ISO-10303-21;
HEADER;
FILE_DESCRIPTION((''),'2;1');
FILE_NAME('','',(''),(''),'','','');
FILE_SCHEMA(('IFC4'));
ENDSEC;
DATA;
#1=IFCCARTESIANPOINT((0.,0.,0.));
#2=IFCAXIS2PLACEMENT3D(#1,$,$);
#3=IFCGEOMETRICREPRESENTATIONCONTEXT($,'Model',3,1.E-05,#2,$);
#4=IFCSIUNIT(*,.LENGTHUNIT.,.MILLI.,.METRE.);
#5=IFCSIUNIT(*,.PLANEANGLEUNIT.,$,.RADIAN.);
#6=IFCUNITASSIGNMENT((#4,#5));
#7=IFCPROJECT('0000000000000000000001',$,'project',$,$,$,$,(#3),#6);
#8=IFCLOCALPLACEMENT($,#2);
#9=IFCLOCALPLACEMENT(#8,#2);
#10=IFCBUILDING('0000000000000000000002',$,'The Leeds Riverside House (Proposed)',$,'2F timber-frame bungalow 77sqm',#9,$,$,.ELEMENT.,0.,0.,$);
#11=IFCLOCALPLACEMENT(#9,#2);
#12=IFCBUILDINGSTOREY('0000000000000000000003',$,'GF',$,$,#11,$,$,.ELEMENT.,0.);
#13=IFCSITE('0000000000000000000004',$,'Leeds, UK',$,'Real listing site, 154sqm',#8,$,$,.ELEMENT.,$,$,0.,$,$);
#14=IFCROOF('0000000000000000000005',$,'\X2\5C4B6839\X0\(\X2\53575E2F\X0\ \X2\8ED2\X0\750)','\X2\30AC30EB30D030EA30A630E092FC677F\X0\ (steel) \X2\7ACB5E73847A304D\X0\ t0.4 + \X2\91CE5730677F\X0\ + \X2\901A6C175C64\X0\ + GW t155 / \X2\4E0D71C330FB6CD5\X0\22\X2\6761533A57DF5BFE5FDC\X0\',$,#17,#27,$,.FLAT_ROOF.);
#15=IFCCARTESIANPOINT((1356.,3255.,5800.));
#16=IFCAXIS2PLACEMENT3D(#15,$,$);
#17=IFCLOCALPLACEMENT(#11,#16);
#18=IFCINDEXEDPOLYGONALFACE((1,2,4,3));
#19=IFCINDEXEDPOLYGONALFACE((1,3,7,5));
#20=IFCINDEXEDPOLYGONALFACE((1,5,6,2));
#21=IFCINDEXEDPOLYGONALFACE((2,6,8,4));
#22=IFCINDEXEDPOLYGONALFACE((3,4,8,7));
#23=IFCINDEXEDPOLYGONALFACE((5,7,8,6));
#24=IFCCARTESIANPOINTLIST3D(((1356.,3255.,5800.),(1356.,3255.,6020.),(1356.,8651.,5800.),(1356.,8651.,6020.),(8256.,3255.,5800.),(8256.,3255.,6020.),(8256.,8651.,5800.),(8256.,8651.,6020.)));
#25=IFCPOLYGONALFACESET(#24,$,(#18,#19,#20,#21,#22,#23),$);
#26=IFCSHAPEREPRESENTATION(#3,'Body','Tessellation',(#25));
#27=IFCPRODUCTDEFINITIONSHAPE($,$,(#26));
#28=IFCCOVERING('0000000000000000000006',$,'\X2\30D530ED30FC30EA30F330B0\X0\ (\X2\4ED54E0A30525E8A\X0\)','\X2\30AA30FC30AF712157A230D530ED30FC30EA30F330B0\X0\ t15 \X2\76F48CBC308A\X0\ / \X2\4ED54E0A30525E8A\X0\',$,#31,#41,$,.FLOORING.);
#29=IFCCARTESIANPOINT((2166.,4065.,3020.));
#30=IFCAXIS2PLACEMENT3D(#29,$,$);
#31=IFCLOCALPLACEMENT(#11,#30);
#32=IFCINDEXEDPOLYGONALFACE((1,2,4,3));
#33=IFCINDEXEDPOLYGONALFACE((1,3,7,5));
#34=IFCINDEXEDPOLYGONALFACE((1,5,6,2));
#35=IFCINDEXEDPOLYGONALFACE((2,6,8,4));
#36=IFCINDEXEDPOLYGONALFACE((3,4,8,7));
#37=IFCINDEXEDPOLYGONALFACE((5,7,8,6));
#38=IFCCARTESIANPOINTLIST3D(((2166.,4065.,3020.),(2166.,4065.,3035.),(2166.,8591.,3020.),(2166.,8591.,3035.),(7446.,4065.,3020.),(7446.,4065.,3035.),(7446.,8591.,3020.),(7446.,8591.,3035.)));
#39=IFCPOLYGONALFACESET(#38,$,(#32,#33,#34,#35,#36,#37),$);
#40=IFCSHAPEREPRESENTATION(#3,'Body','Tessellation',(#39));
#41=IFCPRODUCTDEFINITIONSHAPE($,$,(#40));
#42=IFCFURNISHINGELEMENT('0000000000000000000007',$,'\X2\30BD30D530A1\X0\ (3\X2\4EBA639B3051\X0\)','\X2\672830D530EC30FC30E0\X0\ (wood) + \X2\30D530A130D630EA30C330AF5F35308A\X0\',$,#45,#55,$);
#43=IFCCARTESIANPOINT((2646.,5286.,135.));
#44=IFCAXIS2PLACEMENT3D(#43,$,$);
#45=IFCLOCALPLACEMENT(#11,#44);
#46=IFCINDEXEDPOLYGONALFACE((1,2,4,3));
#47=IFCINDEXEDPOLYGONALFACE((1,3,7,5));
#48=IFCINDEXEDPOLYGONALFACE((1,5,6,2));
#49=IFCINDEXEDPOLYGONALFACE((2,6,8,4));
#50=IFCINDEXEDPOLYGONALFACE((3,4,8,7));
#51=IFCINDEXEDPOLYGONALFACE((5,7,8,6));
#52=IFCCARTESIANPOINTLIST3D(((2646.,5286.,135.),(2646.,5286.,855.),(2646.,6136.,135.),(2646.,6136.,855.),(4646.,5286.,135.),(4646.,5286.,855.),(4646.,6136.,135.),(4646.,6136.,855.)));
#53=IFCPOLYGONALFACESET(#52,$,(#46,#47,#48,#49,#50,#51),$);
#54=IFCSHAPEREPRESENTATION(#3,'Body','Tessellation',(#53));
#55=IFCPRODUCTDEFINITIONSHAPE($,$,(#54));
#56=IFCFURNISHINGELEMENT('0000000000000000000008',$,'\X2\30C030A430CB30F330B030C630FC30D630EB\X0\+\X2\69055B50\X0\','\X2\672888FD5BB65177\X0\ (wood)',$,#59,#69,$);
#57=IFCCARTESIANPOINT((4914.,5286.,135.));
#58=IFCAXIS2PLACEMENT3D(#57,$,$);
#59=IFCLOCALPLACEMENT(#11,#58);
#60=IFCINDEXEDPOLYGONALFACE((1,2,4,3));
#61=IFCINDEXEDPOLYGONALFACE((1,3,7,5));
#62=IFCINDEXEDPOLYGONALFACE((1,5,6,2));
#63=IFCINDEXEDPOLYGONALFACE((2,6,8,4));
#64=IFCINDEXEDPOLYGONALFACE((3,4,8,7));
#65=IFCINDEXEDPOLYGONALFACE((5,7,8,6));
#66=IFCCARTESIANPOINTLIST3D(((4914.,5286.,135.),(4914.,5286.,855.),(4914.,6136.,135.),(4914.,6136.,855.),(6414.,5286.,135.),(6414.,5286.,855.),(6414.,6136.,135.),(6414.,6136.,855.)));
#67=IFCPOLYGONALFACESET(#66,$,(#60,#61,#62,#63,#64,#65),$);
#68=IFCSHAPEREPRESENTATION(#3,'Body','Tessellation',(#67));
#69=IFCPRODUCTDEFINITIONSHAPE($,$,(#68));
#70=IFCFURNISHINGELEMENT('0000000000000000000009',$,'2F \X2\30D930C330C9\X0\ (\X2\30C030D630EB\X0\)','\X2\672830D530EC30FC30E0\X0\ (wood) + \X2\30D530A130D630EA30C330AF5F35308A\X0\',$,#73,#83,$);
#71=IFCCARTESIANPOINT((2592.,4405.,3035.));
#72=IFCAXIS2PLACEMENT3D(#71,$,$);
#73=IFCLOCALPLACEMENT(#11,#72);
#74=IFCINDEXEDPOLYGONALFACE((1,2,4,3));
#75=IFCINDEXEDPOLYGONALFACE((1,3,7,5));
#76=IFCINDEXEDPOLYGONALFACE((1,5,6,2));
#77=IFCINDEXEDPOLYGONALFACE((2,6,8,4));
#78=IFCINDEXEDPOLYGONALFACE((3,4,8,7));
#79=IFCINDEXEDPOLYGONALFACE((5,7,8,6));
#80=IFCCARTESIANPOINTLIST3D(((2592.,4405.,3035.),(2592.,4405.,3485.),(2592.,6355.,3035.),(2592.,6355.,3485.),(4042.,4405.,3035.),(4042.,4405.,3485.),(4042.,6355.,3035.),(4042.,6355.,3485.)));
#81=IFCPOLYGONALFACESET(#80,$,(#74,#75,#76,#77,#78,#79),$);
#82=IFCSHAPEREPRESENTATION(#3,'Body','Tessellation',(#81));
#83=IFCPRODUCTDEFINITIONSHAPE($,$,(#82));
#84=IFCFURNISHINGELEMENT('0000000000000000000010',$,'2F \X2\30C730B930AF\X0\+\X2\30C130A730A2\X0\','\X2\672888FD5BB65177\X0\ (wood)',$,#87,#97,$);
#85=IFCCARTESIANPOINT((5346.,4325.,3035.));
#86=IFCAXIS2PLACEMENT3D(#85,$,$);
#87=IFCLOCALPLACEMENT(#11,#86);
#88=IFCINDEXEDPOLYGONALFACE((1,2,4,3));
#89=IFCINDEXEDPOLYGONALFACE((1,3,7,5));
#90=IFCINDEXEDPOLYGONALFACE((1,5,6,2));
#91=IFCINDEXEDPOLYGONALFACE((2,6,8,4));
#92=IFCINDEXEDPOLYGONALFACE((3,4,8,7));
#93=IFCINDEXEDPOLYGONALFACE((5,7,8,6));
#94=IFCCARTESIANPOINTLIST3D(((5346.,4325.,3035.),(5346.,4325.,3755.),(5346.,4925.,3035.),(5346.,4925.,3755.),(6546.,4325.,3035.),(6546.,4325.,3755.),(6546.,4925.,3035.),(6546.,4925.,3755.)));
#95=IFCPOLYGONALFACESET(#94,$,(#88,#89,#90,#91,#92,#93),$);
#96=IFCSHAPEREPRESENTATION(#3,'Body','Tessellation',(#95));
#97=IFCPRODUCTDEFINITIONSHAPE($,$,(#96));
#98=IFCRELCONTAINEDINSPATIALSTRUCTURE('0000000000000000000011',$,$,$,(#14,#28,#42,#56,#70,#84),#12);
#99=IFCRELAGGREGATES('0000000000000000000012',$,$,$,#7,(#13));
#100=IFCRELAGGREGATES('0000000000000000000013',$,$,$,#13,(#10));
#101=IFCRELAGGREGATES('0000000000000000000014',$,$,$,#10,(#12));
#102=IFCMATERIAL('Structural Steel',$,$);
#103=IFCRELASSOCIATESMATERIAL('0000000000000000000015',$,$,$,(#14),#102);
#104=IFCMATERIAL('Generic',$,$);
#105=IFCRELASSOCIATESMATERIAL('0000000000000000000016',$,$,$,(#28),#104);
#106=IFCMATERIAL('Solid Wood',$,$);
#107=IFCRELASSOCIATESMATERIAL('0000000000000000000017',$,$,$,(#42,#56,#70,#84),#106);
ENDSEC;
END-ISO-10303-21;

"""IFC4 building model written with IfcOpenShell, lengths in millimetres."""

from ifc_helpers import new_model, si_unit, frame, frame_2d, origin, place, context, project, spatial, rectangle, extrude, material, element, save


model = new_model("IFC4")

# Units and contexts
model_context = context("Model", 3, precision=1e-05, world=origin())
ifc_project = project(units=[si_unit("LENGTHUNIT", "METRE", prefix="MILLI"), si_unit("PLANEANGLEUNIT", "RADIAN")], contexts=[model_context])

# Site, building, storey
site_placement = place(None, origin())
site = spatial("IfcSite", under=ifc_project, at=site_placement, Name="Leeds, UK", ObjectType="Real listing site, 154sqm", CompositionType="ELEMENT", RefElevation=0.0)
building_placement = place(site_placement, origin())
building = spatial("IfcBuilding", under=site, at=building_placement, Name="The Leeds Riverside House (Proposed)", ObjectType="2F timber-frame bungalow 77sqm", CompositionType="ELEMENT", ElevationOfRefHeight=0.0, ElevationOfTerrain=0.0)
storey_placement = place(building_placement, origin())
storey = spatial("IfcBuildingStorey", under=building, at=storey_placement, Name="GF", CompositionType="ELEMENT", Elevation=0.0)

# Shared definitions
ifc_material_1 = material(Name="Solid Wood")

# Roof
ifc_material_2 = material(Name="Structural Steel")
for number, where, name in (
    (1, (1356.0, 3255.0, 5800.0), "屋根(南帯 軒750)"),
):
    element("IfcRoof", number, at=place(storey_placement, frame(where)), inside=storey, material=ifc_material_2, Name=name, Description="ガルバリウム鋼板 (steel) 立平葺き t0.4 + 野地板 + 通気層 + GW t155 / 不燃・法22条区域対応", PredefinedType="FLAT_ROOF", context=model_context, shape_type="SweptSolid", body=[
        extrude(rectangle(XDim=6900.0, YDim=5396.0, at=frame_2d((3450.0, 2698.0))), frame((1356.0, 3255.0, 5800.0)), (0.0, 0.0, 1.0), 220.0),
    ])

# Covering
ifc_material_3 = material(Name="Generic")
covering_placement = place(storey_placement, frame((2166.0, 4065.0, 3020.0)))
element("IfcCovering", 2, at=covering_placement, inside=storey, material=ifc_material_3, Name="フローリング (仕上げ床)", Description="オーク無垢フローリング t15 直貼り / 仕上げ床", PredefinedType="FLOORING", context=model_context, shape_type="SweptSolid", body=[
    extrude(rectangle(XDim=5280.0, YDim=4526.0, at=frame_2d((2640.0, 2263.0))), frame((2166.0, 4065.0, 3020.0)), (0.0, 0.0, 1.0), 15.0),
])

# Furnishing elements
furnishing_1_placement = place(storey_placement, frame((2646.0, 5286.0, 135.0)))
element("IfcFurnishingElement", 3, at=furnishing_1_placement, inside=storey, material=ifc_material_1, Name="ソファ (3人掛け)", Description="木フレーム (wood) + ファブリック張り", context=model_context, shape_type="SweptSolid", body=[
    extrude(rectangle(XDim=2000.0, YDim=850.0, at=frame_2d((1000.0, 425.0))), frame((2646.0, 5286.0, 135.0)), (0.0, 0.0, 1.0), 720.0),
])
furnishing_2_placement = place(storey_placement, frame((4914.0, 5286.0, 135.0)))
element("IfcFurnishingElement", 4, at=furnishing_2_placement, inside=storey, material=ifc_material_1, Name="ダイニングテーブル+椅子", Description="木製家具 (wood)", context=model_context, shape_type="SweptSolid", body=[
    extrude(rectangle(XDim=1500.0, YDim=850.0, at=frame_2d((750.0, 425.0))), frame((4914.0, 5286.0, 135.0)), (0.0, 0.0, 1.0), 720.0),
])
furnishing_3_placement = place(storey_placement, frame((2592.0, 4405.0, 3035.0)))
element("IfcFurnishingElement", 5, at=furnishing_3_placement, inside=storey, material=ifc_material_1, Name="2F ベッド (ダブル)", Description="木フレーム (wood) + ファブリック張り", context=model_context, shape_type="SweptSolid", body=[
    extrude(rectangle(XDim=1450.0, YDim=1950.0, at=frame_2d((725.0, 975.0))), frame((2592.0, 4405.0, 3035.0)), (0.0, 0.0, 1.0), 450.0),
])
furnishing_4_placement = place(storey_placement, frame((5346.0, 4325.0, 3035.0)))
element("IfcFurnishingElement", 6, at=furnishing_4_placement, inside=storey, material=ifc_material_1, Name="2F デスク+チェア", Description="木製家具 (wood)", context=model_context, shape_type="SweptSolid", body=[
    extrude(rectangle(XDim=1200.0, YDim=600.0, at=frame_2d((600.0, 300.0))), frame((5346.0, 4325.0, 3035.0)), (0.0, 0.0, 1.0), 720.0),
])

save(model, "model.ifc")
